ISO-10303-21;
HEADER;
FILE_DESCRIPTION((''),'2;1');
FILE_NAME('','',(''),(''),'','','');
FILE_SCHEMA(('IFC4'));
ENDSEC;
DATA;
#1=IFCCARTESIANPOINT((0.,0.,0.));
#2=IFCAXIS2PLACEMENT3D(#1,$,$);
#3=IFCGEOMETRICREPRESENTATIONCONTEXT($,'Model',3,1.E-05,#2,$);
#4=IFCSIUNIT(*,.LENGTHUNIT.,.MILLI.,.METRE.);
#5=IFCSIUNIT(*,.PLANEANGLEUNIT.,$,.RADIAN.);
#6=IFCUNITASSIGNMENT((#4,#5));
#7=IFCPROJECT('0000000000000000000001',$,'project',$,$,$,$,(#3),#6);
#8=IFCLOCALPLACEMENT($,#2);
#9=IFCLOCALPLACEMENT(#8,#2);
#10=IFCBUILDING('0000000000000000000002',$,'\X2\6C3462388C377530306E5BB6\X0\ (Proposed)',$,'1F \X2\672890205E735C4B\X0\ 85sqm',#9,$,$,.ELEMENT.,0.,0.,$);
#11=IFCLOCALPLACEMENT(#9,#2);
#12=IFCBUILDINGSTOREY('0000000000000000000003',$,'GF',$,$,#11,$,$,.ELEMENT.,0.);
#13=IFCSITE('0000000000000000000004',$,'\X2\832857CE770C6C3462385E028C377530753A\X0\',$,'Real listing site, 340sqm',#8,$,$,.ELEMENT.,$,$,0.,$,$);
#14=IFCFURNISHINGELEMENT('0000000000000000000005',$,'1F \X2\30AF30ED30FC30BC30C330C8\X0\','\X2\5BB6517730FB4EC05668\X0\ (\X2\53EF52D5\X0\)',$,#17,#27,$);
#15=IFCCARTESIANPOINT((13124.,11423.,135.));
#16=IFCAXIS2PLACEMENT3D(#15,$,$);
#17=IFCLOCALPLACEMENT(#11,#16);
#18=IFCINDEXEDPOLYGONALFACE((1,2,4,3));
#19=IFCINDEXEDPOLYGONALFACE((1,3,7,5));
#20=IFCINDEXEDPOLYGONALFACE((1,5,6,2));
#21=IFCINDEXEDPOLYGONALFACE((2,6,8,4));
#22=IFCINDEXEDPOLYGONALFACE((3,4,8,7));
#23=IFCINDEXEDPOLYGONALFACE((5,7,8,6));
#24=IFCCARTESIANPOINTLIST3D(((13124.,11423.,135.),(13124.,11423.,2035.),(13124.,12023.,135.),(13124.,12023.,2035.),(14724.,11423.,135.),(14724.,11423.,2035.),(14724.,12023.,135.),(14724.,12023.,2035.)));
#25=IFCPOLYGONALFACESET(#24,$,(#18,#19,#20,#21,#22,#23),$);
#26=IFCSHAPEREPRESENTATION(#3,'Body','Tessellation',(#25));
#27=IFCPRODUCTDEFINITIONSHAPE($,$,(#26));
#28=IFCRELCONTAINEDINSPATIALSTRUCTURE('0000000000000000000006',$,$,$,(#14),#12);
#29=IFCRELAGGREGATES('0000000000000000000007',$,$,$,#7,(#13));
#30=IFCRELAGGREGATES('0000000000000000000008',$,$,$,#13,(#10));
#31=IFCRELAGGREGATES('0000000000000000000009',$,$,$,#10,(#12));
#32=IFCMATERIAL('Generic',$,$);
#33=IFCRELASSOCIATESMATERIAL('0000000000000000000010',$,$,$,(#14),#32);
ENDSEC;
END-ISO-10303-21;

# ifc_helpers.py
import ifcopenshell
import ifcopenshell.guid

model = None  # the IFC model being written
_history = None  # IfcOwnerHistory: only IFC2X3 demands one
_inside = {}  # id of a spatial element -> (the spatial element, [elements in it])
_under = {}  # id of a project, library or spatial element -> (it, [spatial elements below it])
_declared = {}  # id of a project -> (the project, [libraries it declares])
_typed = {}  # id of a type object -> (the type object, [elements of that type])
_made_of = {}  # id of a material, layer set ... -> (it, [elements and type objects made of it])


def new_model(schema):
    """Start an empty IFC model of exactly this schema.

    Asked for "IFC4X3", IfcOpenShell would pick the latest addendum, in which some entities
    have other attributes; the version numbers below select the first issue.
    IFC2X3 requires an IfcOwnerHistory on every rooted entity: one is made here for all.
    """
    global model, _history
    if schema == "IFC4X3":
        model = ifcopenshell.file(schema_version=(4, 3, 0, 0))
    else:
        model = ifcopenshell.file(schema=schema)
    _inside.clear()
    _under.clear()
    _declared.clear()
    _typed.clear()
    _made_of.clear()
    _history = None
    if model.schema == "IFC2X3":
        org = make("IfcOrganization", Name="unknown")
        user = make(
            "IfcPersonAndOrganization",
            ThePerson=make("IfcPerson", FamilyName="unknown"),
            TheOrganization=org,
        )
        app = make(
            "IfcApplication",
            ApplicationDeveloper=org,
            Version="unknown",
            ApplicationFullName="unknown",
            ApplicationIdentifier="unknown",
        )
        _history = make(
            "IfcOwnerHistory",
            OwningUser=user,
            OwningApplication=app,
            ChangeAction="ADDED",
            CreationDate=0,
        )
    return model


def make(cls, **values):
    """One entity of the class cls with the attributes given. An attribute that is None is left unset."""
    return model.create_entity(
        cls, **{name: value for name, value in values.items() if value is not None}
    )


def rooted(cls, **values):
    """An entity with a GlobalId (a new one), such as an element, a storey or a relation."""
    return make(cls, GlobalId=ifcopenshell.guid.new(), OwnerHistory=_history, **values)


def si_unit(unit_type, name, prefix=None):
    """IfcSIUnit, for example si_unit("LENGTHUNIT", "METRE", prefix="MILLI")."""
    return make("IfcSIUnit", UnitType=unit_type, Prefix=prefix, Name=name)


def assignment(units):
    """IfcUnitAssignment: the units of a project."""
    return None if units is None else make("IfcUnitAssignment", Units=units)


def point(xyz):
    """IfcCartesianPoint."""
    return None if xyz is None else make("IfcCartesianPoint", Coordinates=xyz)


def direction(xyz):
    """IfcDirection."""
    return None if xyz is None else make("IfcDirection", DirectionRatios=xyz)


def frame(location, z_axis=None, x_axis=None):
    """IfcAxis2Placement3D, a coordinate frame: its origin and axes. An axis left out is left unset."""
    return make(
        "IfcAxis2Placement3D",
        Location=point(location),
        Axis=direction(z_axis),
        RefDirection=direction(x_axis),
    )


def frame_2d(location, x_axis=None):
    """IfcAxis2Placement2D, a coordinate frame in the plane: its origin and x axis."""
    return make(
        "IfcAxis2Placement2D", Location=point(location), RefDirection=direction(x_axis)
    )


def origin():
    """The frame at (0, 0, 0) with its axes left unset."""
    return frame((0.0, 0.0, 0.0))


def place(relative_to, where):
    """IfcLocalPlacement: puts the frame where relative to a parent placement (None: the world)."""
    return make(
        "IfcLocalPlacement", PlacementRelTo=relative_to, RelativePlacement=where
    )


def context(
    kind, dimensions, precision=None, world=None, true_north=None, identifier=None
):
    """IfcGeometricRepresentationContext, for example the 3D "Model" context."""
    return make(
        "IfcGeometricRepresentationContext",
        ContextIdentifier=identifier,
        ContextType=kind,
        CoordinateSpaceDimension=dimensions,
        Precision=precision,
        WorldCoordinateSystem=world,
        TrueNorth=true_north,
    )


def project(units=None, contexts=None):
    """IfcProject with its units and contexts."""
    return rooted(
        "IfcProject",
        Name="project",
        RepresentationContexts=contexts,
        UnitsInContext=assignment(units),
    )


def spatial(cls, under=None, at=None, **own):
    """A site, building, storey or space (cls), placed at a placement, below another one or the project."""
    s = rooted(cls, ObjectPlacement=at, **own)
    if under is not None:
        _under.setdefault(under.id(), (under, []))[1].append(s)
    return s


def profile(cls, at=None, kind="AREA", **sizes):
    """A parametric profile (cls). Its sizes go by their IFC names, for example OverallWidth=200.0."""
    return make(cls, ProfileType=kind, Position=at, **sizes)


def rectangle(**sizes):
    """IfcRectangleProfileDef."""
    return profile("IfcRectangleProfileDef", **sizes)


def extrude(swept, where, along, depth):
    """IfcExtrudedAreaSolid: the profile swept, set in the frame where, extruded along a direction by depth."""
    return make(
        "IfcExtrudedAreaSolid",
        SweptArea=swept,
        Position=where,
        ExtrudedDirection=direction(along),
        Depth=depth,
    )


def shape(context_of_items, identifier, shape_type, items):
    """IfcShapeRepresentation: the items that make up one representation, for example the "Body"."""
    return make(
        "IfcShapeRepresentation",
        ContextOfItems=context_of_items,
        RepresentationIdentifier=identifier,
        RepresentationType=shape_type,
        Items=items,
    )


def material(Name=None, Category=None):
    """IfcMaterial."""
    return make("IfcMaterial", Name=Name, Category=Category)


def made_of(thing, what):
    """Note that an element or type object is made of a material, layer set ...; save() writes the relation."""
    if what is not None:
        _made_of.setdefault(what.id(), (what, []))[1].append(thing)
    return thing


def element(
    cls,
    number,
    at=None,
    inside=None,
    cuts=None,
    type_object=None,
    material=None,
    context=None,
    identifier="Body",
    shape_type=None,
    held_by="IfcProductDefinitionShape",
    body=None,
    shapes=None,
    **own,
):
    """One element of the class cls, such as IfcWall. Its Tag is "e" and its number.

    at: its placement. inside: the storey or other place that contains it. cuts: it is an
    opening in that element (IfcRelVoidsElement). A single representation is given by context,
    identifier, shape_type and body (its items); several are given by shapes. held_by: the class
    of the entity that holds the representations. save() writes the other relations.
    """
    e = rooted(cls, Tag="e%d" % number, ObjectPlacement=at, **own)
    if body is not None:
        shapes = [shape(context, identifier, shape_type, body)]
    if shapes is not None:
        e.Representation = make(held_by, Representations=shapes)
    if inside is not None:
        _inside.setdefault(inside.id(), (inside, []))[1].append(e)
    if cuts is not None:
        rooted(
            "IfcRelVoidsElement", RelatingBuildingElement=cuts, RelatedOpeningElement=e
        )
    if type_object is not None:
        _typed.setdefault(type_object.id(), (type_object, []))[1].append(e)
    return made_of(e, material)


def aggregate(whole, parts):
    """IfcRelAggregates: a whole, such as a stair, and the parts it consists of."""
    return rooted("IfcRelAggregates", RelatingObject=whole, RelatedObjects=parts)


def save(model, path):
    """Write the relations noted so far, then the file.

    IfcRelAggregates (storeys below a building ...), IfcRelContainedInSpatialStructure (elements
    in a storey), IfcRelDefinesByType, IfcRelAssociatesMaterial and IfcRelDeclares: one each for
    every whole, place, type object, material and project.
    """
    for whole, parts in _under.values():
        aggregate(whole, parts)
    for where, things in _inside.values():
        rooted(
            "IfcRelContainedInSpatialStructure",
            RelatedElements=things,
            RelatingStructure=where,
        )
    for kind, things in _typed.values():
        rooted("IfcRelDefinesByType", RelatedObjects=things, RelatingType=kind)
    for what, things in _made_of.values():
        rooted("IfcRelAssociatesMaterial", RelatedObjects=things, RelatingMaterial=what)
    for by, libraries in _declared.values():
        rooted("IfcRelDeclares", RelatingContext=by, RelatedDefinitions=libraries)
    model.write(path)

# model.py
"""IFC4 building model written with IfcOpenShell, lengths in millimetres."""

from ifc_helpers import new_model, si_unit, frame, frame_2d, origin, place, context, project, spatial, rectangle, extrude, material, element, save


model = new_model("IFC4")

# Units and contexts
model_context = context("Model", 3, precision=1e-05, world=origin())
ifc_project = project(units=[si_unit("LENGTHUNIT", "METRE", prefix="MILLI"), si_unit("PLANEANGLEUNIT", "RADIAN")], contexts=[model_context])

# Site, building, storey
site_placement = place(None, origin())
site = spatial("IfcSite", under=ifc_project, at=site_placement, Name="茨城県水戸市谷田町", ObjectType="Real listing site, 340sqm", CompositionType="ELEMENT", RefElevation=0.0)
building_placement = place(site_placement, origin())
building = spatial("IfcBuilding", under=site, at=building_placement, Name="水戸谷田の家 (Proposed)", ObjectType="1F 木造平屋 85sqm", CompositionType="ELEMENT", ElevationOfRefHeight=0.0, ElevationOfTerrain=0.0)
storey_placement = place(building_placement, origin())
storey = spatial("IfcBuildingStorey", under=building, at=storey_placement, Name="GF", CompositionType="ELEMENT", Elevation=0.0)

# Shared definitions
ifc_material_1 = material(Name="Generic")

# Furnishing element
furnishing_placement = place(storey_placement, frame((13124.0, 11423.0, 135.0)))
element("IfcFurnishingElement", 1, at=furnishing_placement, inside=storey, material=ifc_material_1, Name="1F クローゼット", Description="家具・什器 (可動)", context=model_context, shape_type="SweptSolid", body=[
    extrude(rectangle(XDim=1600.0, YDim=600.0, at=frame_2d((800.0, 300.0))), frame((13124.0, 11423.0, 135.0)), (0.0, 0.0, 1.0), 1900.0),
])

save(model, "model.ifc")
